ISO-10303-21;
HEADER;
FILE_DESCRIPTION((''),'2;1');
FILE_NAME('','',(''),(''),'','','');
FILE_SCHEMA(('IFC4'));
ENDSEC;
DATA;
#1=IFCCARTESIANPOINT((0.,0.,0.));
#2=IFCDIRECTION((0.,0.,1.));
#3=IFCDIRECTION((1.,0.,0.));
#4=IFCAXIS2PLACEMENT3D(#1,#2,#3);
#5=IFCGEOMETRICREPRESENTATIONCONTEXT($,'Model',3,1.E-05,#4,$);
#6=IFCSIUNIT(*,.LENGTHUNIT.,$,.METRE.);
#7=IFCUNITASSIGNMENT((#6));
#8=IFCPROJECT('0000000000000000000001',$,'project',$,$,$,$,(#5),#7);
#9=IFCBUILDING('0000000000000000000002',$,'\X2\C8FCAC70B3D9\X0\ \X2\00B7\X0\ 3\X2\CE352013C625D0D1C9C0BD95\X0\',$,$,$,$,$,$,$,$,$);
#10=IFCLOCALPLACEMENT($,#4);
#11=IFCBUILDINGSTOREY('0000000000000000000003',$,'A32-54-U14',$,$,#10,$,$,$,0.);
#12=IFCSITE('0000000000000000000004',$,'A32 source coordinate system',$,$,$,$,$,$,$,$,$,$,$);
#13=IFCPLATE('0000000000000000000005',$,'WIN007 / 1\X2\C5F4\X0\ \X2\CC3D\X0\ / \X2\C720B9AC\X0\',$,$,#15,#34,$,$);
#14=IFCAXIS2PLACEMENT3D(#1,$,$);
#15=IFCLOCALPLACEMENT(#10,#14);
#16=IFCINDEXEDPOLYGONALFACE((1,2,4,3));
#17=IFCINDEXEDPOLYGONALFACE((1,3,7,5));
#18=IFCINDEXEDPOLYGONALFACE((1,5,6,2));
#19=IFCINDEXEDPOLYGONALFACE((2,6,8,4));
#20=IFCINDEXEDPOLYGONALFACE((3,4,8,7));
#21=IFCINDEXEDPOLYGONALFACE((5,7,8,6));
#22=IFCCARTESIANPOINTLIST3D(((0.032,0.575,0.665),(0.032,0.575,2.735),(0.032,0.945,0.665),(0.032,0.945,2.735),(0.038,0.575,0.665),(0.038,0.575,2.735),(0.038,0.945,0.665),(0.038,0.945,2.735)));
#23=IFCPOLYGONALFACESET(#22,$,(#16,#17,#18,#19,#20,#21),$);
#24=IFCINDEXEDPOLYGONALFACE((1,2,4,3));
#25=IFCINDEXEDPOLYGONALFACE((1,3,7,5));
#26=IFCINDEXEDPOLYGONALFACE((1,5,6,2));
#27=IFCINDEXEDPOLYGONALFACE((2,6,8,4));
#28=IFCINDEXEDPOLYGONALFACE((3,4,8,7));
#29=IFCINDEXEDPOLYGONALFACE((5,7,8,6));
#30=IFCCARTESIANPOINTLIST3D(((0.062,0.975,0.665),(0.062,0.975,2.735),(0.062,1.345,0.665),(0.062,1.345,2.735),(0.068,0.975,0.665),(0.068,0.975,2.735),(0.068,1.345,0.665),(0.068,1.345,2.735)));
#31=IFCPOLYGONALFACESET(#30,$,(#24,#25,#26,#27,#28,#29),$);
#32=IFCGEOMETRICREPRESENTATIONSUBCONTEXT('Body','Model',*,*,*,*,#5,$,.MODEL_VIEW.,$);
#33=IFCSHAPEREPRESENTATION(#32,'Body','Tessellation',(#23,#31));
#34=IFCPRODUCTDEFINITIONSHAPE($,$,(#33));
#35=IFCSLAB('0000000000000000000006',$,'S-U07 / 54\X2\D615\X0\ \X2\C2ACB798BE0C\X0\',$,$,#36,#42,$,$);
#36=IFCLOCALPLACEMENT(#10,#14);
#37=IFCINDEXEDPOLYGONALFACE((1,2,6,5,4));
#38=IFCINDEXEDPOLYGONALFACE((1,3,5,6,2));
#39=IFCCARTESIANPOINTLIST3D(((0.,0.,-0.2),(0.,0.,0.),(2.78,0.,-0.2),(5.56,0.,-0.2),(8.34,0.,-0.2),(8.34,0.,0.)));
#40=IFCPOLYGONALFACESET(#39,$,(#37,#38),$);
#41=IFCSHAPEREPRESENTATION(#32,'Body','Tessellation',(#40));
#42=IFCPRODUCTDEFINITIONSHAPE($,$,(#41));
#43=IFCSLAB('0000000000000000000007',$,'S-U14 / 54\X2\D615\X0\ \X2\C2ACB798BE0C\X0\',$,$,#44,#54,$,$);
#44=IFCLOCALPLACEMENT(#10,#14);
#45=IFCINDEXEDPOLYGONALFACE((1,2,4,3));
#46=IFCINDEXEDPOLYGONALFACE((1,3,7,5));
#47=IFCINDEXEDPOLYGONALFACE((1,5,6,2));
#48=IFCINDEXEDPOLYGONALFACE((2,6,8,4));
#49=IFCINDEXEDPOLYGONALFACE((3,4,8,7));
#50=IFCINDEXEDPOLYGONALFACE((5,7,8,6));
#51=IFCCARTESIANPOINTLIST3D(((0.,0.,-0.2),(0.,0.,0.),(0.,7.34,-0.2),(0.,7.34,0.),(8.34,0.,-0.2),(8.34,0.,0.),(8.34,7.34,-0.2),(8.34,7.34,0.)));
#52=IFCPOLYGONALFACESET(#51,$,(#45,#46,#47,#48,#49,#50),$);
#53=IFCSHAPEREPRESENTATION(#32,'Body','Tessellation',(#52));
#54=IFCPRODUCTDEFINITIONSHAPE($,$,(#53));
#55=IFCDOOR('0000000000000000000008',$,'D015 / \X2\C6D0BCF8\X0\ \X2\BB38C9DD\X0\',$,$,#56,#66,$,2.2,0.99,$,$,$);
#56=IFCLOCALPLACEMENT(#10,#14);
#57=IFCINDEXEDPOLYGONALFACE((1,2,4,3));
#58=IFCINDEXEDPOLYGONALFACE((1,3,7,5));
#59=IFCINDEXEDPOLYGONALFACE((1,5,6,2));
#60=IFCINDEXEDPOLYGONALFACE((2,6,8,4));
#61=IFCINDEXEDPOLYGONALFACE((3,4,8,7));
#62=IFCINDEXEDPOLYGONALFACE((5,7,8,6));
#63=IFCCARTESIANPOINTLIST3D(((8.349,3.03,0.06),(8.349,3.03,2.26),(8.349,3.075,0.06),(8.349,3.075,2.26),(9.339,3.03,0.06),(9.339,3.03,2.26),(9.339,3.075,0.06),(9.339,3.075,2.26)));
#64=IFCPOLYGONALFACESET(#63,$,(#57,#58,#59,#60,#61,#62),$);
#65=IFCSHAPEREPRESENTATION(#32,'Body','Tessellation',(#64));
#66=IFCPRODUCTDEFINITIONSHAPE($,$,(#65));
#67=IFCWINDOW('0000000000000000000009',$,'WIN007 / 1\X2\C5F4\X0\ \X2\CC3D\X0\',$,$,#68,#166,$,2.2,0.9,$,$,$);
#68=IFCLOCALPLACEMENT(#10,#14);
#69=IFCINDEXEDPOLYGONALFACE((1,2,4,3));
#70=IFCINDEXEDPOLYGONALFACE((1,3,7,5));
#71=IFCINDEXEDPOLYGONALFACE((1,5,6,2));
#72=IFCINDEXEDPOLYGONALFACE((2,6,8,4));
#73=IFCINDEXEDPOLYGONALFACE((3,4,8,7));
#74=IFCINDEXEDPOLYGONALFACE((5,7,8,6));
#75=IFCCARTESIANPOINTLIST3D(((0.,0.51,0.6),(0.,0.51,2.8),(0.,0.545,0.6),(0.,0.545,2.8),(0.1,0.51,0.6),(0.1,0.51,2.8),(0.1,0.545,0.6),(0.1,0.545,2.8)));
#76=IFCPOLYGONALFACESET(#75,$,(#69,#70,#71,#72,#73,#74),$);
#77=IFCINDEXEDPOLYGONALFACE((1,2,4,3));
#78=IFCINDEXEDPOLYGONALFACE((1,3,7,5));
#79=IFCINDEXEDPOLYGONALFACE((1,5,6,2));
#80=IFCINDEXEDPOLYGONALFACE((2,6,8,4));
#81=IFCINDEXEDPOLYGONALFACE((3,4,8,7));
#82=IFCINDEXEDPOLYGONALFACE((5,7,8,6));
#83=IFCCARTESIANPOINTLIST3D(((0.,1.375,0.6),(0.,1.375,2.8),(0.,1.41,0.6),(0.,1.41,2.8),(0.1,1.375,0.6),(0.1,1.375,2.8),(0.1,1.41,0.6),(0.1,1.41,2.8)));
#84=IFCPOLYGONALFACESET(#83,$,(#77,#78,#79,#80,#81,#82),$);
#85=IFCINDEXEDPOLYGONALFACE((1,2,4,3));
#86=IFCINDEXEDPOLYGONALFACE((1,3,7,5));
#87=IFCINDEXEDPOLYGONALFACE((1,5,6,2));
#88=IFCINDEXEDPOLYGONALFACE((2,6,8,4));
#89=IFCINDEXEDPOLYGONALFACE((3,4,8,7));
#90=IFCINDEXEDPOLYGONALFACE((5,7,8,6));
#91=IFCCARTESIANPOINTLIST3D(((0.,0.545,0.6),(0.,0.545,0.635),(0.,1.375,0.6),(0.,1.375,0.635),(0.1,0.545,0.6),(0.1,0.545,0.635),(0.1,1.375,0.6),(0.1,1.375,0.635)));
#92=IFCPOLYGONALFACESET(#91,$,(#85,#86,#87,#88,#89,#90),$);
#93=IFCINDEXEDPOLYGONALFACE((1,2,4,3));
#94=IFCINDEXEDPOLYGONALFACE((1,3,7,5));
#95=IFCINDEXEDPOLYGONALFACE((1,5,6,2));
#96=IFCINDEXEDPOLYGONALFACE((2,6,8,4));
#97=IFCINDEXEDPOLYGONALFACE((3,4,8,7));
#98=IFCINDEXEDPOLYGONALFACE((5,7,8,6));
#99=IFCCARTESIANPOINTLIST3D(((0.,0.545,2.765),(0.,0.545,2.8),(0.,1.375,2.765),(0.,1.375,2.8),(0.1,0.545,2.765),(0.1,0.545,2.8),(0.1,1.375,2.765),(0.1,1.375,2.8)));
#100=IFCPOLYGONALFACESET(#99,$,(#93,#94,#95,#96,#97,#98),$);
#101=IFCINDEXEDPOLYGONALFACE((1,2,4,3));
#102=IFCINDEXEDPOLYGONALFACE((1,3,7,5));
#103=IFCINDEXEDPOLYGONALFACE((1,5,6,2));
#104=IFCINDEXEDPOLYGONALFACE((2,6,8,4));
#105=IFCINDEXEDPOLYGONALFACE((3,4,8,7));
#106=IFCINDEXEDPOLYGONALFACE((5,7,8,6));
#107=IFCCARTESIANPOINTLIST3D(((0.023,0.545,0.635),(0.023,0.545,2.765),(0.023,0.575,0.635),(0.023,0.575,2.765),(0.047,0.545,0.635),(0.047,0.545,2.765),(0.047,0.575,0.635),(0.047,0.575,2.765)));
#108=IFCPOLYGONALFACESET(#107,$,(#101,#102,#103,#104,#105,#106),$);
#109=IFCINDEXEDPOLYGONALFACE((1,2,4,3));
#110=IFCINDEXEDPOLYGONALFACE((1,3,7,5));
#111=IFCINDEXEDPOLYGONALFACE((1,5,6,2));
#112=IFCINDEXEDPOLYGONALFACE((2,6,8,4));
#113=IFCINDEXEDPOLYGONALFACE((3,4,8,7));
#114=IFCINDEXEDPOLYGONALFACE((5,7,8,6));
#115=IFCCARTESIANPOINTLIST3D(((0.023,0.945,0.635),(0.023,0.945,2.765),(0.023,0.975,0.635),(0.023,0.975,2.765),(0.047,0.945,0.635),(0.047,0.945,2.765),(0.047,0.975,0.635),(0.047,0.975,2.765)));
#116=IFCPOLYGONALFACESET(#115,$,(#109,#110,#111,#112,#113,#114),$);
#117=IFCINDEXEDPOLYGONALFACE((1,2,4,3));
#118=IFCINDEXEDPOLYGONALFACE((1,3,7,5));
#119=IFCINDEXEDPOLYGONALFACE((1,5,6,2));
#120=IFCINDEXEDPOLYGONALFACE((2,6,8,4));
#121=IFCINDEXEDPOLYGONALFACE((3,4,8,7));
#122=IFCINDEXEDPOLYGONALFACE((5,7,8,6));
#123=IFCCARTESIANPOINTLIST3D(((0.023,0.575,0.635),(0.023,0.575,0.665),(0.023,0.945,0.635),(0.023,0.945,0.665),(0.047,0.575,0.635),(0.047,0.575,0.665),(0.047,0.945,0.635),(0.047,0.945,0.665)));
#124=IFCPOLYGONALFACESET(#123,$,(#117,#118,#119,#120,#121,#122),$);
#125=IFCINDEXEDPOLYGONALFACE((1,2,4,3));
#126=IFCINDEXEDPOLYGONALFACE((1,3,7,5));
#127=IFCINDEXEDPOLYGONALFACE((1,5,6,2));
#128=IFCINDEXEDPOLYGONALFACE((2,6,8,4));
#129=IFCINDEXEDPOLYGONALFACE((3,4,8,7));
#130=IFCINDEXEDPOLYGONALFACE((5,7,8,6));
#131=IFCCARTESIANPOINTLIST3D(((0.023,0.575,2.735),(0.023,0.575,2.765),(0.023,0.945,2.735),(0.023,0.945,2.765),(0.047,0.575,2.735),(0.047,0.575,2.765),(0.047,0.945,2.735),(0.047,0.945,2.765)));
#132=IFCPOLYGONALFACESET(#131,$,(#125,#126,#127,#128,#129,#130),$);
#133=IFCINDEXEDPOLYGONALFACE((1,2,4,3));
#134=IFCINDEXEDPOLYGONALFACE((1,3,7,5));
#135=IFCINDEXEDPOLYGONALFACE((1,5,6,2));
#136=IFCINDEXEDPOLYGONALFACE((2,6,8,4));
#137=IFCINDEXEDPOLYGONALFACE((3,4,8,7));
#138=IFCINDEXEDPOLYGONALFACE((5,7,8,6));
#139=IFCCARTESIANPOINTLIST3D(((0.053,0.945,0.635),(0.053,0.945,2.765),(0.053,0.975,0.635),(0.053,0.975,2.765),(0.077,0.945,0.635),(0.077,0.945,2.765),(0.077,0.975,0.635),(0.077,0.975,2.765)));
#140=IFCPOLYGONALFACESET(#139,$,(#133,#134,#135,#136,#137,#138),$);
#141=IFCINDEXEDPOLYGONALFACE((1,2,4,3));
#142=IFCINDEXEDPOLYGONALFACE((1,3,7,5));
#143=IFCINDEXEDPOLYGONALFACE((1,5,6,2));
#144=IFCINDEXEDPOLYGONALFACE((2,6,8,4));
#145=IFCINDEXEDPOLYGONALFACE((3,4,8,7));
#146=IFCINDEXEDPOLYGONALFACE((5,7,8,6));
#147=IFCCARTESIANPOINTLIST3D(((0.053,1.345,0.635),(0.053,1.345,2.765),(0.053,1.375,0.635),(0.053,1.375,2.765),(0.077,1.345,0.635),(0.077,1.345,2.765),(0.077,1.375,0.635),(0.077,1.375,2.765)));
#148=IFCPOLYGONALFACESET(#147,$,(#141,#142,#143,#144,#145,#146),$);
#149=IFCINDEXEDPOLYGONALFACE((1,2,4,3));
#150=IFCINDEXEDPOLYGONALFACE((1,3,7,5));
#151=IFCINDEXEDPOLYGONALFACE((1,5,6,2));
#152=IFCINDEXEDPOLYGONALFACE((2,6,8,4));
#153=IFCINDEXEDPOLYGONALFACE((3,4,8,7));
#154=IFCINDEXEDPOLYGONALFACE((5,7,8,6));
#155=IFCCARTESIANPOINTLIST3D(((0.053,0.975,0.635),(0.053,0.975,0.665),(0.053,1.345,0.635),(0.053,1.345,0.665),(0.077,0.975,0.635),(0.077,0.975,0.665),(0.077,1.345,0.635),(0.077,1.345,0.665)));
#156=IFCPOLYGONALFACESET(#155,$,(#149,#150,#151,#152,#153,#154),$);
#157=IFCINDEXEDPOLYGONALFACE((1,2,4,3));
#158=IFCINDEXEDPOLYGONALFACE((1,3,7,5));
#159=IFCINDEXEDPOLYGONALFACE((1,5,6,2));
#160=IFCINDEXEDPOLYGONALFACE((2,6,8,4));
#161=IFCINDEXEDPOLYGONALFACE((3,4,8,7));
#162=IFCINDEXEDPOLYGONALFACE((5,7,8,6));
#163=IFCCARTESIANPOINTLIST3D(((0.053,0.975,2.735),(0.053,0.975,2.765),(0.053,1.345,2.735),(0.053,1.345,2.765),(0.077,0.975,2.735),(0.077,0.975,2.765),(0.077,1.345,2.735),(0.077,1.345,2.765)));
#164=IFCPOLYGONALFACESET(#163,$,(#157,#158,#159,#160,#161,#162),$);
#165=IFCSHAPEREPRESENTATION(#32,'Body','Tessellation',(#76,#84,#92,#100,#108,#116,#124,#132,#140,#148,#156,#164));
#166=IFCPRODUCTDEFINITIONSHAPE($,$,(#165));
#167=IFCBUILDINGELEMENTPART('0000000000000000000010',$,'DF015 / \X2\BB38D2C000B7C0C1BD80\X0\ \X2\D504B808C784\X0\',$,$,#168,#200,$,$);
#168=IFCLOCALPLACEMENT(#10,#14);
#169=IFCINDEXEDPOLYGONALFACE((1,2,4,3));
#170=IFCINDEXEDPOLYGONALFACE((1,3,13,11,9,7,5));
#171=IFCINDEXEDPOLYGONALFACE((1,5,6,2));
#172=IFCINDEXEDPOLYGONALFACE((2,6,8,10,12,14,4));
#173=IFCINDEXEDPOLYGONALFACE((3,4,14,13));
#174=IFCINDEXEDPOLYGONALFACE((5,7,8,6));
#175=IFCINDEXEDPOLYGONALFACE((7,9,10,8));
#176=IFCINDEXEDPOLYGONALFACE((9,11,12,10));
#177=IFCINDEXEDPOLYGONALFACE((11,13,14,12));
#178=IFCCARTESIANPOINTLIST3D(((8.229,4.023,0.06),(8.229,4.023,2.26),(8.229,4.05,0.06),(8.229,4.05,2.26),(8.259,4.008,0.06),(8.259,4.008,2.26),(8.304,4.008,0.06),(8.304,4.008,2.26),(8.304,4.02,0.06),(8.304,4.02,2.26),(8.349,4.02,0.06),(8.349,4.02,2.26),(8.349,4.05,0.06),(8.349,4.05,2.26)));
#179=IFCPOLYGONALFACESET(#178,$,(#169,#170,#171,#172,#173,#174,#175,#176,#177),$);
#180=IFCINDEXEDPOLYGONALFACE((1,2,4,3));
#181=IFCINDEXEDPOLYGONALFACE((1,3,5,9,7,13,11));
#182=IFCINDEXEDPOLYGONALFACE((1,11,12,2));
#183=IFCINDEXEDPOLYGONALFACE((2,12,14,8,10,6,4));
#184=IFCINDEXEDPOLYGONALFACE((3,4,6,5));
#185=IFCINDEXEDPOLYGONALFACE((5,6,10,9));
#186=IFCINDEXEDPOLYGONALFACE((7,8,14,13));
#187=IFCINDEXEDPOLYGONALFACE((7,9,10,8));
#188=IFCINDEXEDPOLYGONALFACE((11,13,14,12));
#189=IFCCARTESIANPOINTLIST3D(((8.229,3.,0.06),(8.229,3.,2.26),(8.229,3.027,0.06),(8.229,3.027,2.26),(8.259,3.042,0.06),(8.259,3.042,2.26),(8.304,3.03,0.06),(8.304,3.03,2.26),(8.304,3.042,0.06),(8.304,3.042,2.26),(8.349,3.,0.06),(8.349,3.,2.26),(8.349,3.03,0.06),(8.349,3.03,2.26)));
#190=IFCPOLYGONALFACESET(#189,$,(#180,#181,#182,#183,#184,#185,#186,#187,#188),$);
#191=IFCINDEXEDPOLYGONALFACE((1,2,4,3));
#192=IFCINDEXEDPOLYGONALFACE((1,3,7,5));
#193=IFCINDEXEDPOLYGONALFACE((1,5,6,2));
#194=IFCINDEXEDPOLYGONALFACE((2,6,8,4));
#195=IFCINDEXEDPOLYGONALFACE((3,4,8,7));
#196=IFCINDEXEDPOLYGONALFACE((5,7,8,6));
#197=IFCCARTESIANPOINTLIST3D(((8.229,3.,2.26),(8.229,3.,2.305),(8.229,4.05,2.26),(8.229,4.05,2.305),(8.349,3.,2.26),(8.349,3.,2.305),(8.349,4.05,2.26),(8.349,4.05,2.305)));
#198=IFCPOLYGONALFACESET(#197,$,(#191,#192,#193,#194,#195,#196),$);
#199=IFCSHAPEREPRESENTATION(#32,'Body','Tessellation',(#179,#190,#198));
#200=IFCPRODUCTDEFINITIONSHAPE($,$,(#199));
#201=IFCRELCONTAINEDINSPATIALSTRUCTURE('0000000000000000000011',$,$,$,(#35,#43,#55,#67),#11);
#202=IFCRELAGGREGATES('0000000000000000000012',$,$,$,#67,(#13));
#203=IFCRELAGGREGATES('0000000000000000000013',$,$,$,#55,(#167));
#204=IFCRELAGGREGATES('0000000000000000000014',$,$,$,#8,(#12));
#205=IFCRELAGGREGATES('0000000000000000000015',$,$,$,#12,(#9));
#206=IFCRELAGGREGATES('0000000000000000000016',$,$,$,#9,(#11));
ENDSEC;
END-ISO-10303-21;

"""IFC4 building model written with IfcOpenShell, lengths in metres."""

from ifc_helpers import new_model, si_unit, frame, origin_with_axes, place, context, subcontext, project, spatial, polyline, outline, extrude, element, aggregate, save


model = new_model("IFC4")

# Units and contexts
model_context = context("Model", 3, precision=1e-05, world=origin_with_axes())
body_context = subcontext(model_context, "Body", "Model", "MODEL_VIEW")
ifc_project = project(units=[si_unit("LENGTHUNIT", "METRE")], contexts=[model_context])

# Plate
storey_placement = place(None, origin_with_axes())
window_1_placement = place(storey_placement, origin_with_axes())
plate_1_placement = place(window_1_placement, origin_with_axes())
plate_1 = element("IfcPlate", 1, at=plate_1_placement, Name="WIN007 / 1열 창 / 유리", context=body_context, shape_type="SweptSolid", body=[
    extrude(outline(polyline([(0.032, 0.575), (0.032, 0.945), (0.038, 0.945), (0.038, 0.575), (0.032, 0.575)])), frame((0.0, 0.0, 0.665)), (0.0, 0.0, 1.0), 2.07),
    extrude(outline(polyline([(0.062, 0.975), (0.062, 1.345), (0.068, 1.345), (0.068, 0.975), (0.062, 0.975)])), frame((0.0, 0.0, 0.665)), (0.0, 0.0, 1.0), 2.07),
])

# Site, building, storey
site = spatial("IfcSite", under=ifc_project, Name="A32 source coordinate system")
building = spatial("IfcBuilding", under=site, Name="주거동 · 3층–옥탑지붕")
storey = spatial("IfcBuildingStorey", under=building, at=storey_placement, Name="A32-54-U14", Elevation=0.0)

# Slabs
slab_1_placement = place(storey_placement, origin_with_axes())
element("IfcSlab", 2, at=slab_1_placement, inside=storey, Name="S-U07 / 54형 슬래브", context=body_context, shape_type="SweptSolid", body=[
    extrude(outline(polyline([(0.0, 0.0), (0.0, 0.0), (8.34, 0.0), (8.34, 0.0), (0.0, 0.0)])), frame((0.0, 0.0, -0.2)), (0.0, 0.0, 1.0), 0.2),
])
slab_2_placement = place(storey_placement, origin_with_axes())
element("IfcSlab", 3, at=slab_2_placement, inside=storey, Name="S-U14 / 54형 슬래브", context=body_context, shape_type="SweptSolid", body=[
    extrude(outline(polyline([(0.0, 0.0), (0.0, 7.34), (8.34, 7.34), (8.34, 0.0), (0.0, 0.0)])), frame((0.0, 0.0, -0.2)), (0.0, 0.0, 1.0), 0.2),
])

# Door
door_1_placement = place(storey_placement, origin_with_axes())
door_1 = element("IfcDoor", 4, at=door_1_placement, inside=storey, Name="D015 / 원본 문짝", OverallHeight=2.2, OverallWidth=0.99, context=body_context, shape_type="SweptSolid", body=[
    extrude(outline(polyline([(9.339, 3.075), (9.339, 3.03), (8.349, 3.03), (8.349, 3.075), (9.339, 3.075)])), frame((0.0, 0.0, 0.06)), (0.0, 0.0, 1.0), 2.2),
])

# Window
window_1 = element("IfcWindow", 5, at=window_1_placement, inside=storey, Name="WIN007 / 1열 창", OverallHeight=2.2, OverallWidth=0.9, context=body_context, shape_type="SweptSolid", body=[
    extrude(outline(polyline([(0.0, 0.51), (0.0, 0.545), (0.1, 0.545), (0.1, 0.51), (0.0, 0.51)])), frame((0.0, 0.0, 0.6)), (0.0, 0.0, 1.0), 2.2),
    extrude(outline(polyline([(0.0, 1.375), (0.0, 1.41), (0.1, 1.41), (0.1, 1.375), (0.0, 1.375)])), frame((0.0, 0.0, 0.6)), (0.0, 0.0, 1.0), 2.2),
    extrude(outline(polyline([(0.0, 0.545), (0.0, 1.375), (0.1, 1.375), (0.1, 0.545), (0.0, 0.545)])), frame((0.0, 0.0, 0.6)), (0.0, 0.0, 1.0), 0.035),
    extrude(outline(polyline([(0.0, 0.545), (0.0, 1.375), (0.1, 1.375), (0.1, 0.545), (0.0, 0.545)])), frame((0.0, 0.0, 2.765)), (0.0, 0.0, 1.0), 0.035),
    extrude(outline(polyline([(0.023, 0.545), (0.023, 0.575), (0.047, 0.575), (0.047, 0.545), (0.023, 0.545)])), frame((0.0, 0.0, 0.635)), (0.0, 0.0, 1.0), 2.13),
    extrude(outline(polyline([(0.023, 0.945), (0.023, 0.975), (0.047, 0.975), (0.047, 0.945), (0.023, 0.945)])), frame((0.0, 0.0, 0.635)), (0.0, 0.0, 1.0), 2.13),
    extrude(outline(polyline([(0.023, 0.575), (0.023, 0.945), (0.047, 0.945), (0.047, 0.575), (0.023, 0.575)])), frame((0.0, 0.0, 0.635)), (0.0, 0.0, 1.0), 0.03),
    extrude(outline(polyline([(0.023, 0.575), (0.023, 0.945), (0.047, 0.945), (0.047, 0.575), (0.023, 0.575)])), frame((0.0, 0.0, 2.735)), (0.0, 0.0, 1.0), 0.03),
    extrude(outline(polyline([(0.053, 0.945), (0.053, 0.975), (0.077, 0.975), (0.077, 0.945), (0.053, 0.945)])), frame((0.0, 0.0, 0.635)), (0.0, 0.0, 1.0), 2.13),
    extrude(outline(polyline([(0.053, 1.345), (0.053, 1.375), (0.077, 1.375), (0.077, 1.345), (0.053, 1.345)])), frame((0.0, 0.0, 0.635)), (0.0, 0.0, 1.0), 2.13),
    extrude(outline(polyline([(0.053, 0.975), (0.053, 1.345), (0.077, 1.345), (0.077, 0.975), (0.053, 0.975)])), frame((0.0, 0.0, 0.635)), (0.0, 0.0, 1.0), 0.03),
    extrude(outline(polyline([(0.053, 0.975), (0.053, 1.345), (0.077, 1.345), (0.077, 0.975), (0.053, 0.975)])), frame((0.0, 0.0, 2.735)), (0.0, 0.0, 1.0), 0.03),
])
aggregate(window_1, [plate_1])

# Building element part
building_element_part_1_placement = place(door_1_placement, origin_with_axes())
building_element_part_1 = element("IfcBuildingElementPart", 6, at=building_element_part_1_placement, Name="DF015 / 문틀·상부 프레임", context=body_context, shape_type="SweptSolid", body=[
    extrude(outline(polyline([(8.349, 4.02), (8.304, 4.02), (8.304, 4.008), (8.259, 4.008), (8.229, 4.023), (8.229, 4.05), (8.349, 4.05), (8.349, 4.02)])), frame((0.0, 0.0, 0.06)), (0.0, 0.0, 1.0), 2.2),
    extrude(outline(polyline([(8.229, 3.0), (8.229, 3.027), (8.259, 3.042), (8.304, 3.042), (8.304, 3.03), (8.349, 3.03), (8.349, 3.0), (8.229, 3.0)])), frame((0.0, 0.0, 0.06)), (0.0, 0.0, 1.0), 2.2),
    extrude(outline(polyline([(8.229, 3.0), (8.229, 4.05), (8.349, 4.05), (8.349, 3.0), (8.229, 3.0)])), frame((0.0, 0.0, 2.26)), (0.0, 0.0, 1.0), 0.045),
])
aggregate(door_1, [building_element_part_1])

save(model, "model.ifc")
